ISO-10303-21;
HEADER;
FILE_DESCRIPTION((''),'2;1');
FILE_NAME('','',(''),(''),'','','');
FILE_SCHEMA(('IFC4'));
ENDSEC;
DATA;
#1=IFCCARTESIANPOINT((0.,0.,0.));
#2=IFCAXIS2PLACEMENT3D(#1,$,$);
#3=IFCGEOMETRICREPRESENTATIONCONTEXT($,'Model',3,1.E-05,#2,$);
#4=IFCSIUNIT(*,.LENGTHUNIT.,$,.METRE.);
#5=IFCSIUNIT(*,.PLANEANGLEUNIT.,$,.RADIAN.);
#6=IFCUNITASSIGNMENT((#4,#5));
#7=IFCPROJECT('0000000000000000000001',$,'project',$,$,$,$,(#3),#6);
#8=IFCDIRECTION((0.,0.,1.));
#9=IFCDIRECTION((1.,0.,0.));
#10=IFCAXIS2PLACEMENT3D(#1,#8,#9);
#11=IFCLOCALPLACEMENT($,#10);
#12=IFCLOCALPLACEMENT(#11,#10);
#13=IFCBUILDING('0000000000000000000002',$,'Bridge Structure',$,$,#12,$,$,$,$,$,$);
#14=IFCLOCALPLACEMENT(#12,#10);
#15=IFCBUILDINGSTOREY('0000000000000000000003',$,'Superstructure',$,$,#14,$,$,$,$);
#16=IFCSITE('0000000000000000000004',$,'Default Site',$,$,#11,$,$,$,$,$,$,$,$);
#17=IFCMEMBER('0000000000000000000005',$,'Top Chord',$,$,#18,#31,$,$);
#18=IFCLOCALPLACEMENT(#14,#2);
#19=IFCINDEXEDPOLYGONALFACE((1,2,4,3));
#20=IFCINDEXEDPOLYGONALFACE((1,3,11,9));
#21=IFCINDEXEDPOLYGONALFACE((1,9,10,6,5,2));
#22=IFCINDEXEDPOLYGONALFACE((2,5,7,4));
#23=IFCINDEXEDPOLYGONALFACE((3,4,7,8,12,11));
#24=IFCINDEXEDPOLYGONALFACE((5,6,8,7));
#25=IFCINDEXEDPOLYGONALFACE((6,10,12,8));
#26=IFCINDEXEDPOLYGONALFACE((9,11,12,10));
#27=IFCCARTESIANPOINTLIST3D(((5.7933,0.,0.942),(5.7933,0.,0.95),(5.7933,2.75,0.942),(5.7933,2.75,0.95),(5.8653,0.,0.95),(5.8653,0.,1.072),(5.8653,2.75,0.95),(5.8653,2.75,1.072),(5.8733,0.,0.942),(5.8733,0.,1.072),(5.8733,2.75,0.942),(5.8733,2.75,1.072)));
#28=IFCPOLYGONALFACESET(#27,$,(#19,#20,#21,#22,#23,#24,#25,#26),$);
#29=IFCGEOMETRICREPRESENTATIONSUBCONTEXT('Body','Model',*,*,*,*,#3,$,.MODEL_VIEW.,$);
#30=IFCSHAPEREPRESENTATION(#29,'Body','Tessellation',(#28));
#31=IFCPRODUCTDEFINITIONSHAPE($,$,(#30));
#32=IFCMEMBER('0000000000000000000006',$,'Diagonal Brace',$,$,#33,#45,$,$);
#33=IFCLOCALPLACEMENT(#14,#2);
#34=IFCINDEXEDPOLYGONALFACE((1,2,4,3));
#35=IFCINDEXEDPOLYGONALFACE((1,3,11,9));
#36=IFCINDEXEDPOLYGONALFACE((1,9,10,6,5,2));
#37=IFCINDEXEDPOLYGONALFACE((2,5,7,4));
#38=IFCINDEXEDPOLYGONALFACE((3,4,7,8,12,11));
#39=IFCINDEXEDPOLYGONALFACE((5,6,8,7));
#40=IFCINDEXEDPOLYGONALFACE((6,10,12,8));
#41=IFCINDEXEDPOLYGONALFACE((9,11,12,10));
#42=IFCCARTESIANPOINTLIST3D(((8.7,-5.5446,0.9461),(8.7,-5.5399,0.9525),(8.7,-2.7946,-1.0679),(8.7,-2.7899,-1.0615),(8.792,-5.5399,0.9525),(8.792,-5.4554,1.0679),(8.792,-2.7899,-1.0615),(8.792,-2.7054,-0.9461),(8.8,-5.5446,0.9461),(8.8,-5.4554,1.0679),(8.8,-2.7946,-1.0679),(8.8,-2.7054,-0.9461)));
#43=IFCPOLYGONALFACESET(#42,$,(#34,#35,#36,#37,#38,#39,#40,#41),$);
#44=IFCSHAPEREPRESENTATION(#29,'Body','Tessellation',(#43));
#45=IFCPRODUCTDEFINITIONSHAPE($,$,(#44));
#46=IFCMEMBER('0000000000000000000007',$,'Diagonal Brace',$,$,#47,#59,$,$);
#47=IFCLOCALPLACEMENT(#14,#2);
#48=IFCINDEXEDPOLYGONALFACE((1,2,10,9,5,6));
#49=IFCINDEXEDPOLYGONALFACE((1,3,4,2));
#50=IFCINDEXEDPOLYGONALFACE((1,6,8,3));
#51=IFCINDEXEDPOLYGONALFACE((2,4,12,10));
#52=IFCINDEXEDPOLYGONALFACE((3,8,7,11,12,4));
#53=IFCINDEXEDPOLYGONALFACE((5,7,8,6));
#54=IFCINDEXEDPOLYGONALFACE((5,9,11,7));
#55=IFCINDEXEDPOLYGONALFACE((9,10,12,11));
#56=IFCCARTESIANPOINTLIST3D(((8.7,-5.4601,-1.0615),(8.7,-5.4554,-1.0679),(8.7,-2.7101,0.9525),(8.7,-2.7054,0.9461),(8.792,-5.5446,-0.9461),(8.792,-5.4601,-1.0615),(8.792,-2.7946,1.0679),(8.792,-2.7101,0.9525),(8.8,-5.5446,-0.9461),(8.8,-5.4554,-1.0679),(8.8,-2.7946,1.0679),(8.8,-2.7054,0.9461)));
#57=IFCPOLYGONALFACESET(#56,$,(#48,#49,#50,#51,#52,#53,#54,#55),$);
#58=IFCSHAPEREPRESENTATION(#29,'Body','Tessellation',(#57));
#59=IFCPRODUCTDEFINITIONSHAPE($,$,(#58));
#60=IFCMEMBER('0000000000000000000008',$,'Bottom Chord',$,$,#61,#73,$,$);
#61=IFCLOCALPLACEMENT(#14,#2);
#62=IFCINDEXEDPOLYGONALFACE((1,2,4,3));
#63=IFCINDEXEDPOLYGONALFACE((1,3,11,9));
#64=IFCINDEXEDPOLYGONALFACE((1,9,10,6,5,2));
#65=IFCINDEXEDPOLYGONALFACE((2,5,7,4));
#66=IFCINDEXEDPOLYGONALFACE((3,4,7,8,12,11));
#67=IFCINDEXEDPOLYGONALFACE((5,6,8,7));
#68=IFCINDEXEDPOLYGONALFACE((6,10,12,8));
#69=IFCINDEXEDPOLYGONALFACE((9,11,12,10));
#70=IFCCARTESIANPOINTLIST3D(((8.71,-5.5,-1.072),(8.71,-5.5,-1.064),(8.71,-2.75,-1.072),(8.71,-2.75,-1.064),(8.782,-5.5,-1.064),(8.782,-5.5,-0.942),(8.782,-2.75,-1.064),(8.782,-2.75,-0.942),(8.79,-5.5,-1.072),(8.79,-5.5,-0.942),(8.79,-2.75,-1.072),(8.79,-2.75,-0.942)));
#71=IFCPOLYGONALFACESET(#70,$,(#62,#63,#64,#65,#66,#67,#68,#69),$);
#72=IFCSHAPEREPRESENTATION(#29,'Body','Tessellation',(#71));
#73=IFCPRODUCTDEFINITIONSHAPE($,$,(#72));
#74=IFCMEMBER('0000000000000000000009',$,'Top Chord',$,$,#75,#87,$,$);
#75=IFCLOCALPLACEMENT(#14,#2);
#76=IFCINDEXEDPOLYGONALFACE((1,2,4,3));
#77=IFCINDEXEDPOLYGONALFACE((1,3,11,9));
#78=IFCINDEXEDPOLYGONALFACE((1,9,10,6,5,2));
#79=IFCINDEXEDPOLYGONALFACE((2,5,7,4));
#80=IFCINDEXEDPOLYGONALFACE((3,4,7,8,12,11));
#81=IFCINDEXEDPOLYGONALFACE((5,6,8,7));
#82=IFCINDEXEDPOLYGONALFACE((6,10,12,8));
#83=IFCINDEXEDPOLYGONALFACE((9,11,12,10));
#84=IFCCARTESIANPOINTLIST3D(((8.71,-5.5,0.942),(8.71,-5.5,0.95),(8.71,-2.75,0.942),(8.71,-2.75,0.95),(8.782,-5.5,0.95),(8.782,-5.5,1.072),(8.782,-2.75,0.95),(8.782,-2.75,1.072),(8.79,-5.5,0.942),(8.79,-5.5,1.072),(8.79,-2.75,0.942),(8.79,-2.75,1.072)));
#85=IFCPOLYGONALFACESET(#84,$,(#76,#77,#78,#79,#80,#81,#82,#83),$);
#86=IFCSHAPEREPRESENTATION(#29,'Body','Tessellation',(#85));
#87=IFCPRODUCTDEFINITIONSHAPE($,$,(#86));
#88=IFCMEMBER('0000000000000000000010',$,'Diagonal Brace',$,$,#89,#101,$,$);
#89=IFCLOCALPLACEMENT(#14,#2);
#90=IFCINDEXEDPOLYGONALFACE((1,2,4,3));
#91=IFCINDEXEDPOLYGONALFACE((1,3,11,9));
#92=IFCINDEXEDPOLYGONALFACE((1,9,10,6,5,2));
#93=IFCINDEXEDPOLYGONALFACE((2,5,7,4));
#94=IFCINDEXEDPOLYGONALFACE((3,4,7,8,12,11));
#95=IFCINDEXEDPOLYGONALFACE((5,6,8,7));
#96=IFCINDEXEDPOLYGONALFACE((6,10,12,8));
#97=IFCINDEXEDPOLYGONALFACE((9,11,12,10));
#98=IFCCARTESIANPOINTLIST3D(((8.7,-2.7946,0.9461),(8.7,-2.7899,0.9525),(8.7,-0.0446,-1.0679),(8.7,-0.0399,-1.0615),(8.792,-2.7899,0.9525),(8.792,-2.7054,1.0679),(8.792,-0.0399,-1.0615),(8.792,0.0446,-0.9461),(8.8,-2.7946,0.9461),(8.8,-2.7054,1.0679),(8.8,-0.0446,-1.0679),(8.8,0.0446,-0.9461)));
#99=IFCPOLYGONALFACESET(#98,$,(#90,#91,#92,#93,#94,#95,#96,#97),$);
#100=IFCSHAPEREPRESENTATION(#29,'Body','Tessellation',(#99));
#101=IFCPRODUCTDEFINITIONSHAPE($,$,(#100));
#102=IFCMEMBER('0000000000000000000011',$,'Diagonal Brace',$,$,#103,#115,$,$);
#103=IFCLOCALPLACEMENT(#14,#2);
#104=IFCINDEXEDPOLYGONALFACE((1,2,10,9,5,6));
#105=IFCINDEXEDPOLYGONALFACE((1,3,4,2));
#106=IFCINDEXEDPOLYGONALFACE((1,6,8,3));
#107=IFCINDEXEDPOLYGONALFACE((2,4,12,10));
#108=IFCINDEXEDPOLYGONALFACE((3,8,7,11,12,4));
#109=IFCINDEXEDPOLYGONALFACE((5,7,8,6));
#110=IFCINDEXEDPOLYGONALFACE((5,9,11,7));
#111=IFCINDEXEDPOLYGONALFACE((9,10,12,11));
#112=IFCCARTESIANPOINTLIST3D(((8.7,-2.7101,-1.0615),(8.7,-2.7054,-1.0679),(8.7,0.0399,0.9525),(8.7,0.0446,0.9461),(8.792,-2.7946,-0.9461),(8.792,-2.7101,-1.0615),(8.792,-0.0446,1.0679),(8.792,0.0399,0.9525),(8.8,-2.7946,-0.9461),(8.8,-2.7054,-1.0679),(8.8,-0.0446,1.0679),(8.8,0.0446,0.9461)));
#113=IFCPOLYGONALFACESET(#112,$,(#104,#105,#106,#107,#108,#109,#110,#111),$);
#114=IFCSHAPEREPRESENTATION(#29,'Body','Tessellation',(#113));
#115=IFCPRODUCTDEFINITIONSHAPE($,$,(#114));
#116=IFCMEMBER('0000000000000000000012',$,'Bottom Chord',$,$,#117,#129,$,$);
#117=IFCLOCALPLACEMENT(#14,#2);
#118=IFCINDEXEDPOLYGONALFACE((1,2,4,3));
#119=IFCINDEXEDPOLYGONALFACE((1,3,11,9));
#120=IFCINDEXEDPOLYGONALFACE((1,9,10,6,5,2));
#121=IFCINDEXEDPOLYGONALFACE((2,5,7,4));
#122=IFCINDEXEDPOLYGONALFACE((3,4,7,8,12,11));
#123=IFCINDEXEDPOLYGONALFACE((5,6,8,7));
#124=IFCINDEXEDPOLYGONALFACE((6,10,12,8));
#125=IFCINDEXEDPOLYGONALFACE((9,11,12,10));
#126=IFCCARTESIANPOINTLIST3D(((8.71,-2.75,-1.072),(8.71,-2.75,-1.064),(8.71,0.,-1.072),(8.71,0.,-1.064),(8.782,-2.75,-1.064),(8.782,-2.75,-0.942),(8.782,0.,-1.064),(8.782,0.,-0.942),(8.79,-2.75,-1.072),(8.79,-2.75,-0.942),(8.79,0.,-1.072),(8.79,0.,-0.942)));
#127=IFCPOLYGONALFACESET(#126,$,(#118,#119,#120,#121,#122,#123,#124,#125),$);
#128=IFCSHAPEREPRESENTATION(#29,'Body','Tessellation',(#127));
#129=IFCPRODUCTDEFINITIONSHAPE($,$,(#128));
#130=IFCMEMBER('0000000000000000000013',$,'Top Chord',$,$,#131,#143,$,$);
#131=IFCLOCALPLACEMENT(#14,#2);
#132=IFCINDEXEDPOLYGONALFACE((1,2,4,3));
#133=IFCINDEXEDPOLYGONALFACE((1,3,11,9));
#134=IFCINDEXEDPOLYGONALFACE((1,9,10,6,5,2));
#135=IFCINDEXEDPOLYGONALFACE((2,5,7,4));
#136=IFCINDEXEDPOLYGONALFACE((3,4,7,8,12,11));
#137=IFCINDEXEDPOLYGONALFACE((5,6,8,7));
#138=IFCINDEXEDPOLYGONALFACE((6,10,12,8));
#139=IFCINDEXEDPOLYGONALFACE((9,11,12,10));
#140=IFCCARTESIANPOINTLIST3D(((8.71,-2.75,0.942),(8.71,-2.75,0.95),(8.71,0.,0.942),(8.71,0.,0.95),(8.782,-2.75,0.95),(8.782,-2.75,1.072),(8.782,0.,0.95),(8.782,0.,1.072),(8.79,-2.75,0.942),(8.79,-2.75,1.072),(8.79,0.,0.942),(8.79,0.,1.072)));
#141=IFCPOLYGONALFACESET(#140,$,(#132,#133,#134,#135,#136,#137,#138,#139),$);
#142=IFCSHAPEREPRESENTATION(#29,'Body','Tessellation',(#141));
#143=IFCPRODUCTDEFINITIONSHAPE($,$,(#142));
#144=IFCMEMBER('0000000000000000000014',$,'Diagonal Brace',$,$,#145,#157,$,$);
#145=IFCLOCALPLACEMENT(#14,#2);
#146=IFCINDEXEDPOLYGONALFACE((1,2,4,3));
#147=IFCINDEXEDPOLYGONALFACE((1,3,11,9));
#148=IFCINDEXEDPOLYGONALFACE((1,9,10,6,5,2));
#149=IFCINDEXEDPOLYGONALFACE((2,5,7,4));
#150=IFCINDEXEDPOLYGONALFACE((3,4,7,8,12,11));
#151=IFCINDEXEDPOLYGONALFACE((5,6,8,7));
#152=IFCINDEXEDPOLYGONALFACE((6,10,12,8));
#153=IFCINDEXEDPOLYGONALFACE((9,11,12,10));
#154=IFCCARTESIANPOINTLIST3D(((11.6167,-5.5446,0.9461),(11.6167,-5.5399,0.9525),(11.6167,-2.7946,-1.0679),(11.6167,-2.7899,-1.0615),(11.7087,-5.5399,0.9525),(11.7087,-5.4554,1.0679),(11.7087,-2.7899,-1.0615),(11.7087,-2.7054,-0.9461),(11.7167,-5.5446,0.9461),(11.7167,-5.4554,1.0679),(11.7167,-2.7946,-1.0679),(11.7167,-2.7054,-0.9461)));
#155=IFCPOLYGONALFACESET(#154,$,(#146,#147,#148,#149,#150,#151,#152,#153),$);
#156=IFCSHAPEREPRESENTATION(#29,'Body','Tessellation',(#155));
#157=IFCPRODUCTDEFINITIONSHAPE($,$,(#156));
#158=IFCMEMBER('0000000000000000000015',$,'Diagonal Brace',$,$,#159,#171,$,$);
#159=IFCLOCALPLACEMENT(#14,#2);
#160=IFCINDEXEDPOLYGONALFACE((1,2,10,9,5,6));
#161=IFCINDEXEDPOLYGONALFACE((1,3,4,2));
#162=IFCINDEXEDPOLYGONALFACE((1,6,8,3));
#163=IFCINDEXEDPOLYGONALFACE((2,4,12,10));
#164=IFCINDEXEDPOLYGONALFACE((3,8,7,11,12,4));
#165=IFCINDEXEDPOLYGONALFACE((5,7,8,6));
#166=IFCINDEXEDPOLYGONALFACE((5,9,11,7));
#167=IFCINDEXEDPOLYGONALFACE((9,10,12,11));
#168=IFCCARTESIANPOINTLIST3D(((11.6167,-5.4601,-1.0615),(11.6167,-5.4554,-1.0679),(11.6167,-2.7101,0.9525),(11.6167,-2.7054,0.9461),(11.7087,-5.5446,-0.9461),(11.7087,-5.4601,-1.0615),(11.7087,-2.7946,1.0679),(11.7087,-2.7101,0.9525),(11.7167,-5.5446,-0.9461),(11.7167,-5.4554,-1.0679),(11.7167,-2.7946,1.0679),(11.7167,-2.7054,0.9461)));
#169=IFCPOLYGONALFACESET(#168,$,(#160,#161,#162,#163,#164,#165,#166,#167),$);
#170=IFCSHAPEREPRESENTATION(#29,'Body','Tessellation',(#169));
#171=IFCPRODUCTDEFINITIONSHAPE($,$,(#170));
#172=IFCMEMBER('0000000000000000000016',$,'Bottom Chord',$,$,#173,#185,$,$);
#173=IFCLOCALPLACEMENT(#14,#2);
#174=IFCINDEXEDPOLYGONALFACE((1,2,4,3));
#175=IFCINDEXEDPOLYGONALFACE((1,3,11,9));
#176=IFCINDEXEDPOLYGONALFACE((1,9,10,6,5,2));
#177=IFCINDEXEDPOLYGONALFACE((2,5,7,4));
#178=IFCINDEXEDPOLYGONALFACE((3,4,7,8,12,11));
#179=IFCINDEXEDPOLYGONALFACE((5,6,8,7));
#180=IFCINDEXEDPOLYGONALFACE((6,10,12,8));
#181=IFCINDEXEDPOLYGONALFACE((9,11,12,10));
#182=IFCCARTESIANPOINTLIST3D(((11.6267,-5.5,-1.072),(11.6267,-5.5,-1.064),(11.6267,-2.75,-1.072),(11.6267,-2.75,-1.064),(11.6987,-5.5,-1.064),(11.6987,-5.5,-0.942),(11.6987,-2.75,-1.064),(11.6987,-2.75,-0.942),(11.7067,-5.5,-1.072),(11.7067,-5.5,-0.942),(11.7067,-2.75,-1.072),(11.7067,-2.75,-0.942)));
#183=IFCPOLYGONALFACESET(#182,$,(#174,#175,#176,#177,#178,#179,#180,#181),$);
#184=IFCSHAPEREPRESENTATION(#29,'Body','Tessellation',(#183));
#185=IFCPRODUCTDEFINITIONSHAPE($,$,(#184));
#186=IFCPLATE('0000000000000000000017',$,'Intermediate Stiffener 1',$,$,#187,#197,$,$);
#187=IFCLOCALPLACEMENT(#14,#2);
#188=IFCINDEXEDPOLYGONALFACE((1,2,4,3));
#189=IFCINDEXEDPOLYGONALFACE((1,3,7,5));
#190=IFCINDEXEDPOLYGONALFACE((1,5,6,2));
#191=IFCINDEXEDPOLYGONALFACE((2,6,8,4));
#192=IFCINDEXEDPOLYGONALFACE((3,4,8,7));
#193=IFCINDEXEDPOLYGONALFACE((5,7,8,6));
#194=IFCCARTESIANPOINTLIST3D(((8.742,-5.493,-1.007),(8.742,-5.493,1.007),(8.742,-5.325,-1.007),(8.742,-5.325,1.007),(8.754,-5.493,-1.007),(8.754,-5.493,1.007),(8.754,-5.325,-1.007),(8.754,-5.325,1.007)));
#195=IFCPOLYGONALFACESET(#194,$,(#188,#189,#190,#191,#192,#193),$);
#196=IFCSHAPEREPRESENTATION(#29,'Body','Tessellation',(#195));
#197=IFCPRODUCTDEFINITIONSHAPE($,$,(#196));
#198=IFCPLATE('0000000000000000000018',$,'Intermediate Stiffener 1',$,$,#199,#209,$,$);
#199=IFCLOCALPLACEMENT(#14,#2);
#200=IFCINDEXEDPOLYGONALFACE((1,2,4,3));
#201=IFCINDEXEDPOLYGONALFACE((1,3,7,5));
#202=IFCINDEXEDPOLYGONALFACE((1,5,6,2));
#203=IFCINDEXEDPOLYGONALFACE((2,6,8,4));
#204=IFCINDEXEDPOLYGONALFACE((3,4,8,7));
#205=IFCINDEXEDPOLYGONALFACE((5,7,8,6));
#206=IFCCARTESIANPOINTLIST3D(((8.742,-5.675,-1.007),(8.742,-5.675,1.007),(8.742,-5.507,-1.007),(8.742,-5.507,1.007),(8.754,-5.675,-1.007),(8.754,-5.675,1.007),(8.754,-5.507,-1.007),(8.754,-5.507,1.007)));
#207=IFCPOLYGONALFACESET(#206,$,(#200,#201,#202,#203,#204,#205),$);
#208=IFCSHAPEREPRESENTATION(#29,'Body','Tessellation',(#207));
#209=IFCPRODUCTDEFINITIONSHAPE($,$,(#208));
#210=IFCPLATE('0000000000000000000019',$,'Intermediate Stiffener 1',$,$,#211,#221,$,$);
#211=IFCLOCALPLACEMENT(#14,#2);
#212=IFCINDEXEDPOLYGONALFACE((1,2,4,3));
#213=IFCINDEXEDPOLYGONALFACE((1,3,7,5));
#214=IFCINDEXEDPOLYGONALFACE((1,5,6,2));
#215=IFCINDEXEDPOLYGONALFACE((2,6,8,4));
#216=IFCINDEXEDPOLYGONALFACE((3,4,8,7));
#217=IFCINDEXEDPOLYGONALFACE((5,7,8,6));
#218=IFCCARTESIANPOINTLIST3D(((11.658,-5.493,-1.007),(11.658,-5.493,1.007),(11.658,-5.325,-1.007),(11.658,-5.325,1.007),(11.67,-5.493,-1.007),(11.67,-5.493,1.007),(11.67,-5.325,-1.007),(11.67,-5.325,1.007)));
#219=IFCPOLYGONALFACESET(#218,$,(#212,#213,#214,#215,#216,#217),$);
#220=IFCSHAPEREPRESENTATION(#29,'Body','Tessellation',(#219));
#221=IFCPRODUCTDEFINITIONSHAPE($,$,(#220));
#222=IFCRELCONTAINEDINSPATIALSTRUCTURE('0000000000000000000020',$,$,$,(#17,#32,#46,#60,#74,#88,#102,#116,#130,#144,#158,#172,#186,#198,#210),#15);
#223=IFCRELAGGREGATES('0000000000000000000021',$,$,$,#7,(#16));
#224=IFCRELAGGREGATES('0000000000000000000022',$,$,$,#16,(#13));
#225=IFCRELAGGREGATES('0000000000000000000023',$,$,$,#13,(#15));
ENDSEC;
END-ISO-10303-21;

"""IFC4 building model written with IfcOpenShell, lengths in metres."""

from ifc_helpers import new_model, si_unit, frame, origin, origin_with_axes, origin_2d_with_axis, place, context, subcontext, project, spatial, rectangle, l_section, extrude, element, save


model = new_model("IFC4")

# Units and contexts
model_context = context("Model", 3, precision=1e-05, world=origin())
body_context = subcontext(model_context, "Body", "Model", "MODEL_VIEW")
ifc_project = project(units=[si_unit("LENGTHUNIT", "METRE"), si_unit("PLANEANGLEUNIT", "RADIAN")], contexts=[model_context])

# Site, building, storey
site_placement = place(None, origin_with_axes())
site = spatial("IfcSite", under=ifc_project, at=site_placement, Name="Default Site")
building_placement = place(site_placement, origin_with_axes())
building = spatial("IfcBuilding", under=site, at=building_placement, Name="Bridge Structure")
storey_placement = place(building_placement, origin_with_axes())
storey = spatial("IfcBuildingStorey", under=building, at=storey_placement, Name="Superstructure")

# Members
member_1_placement = place(storey_placement, frame((5.8333, 0.0, 1.007), z_axis=(0.0, 1.0, 0.0), x_axis=(-1.0, 0.0, 0.0)))
element("IfcMember", 1, at=member_1_placement, inside=storey, Name="Top Chord", context=body_context, shape_type="SweptSolid", body=[
    extrude(l_section(Depth=0.13, Width=0.08, Thickness=0.008, at=origin_2d_with_axis()), origin_with_axes(), (0.0, 0.0, 1.0), 2.75),
])
for number, where, z_axis, x_axis, name in (
    (2, (8.75, -5.5, 1.007), (0.0, 0.806778, -0.590855), (-1.0, 0.0, 0.0), "Diagonal Brace"),
    (3, (8.75, -5.5, -1.007), (0.0, 0.806778, 0.590855), (-1.0, 0.0, 0.0), "Diagonal Brace"),
):
    element("IfcMember", number, at=place(storey_placement, frame(where, z_axis=z_axis, x_axis=x_axis)), inside=storey, Name=name, context=body_context, shape_type="SweptSolid", body=[
        extrude(l_section(Depth=0.151, Width=0.1, Thickness=0.008, at=origin_2d_with_axis()), origin_with_axes(), (0.0, 0.0, 1.0), 3.4086),
    ])
for number, where, z_axis, x_axis, name in (
    (4, (8.75, -5.5, -1.007), (0.0, 1.0, 0.0), (-1.0, 0.0, 0.0), "Bottom Chord"),
    (5, (8.75, -5.5, 1.007), (0.0, 1.0, 0.0), (-1.0, 0.0, 0.0), "Top Chord"),
):
    element("IfcMember", number, at=place(storey_placement, frame(where, z_axis=z_axis, x_axis=x_axis)), inside=storey, Name=name, context=body_context, shape_type="SweptSolid", body=[
        extrude(l_section(Depth=0.13, Width=0.08, Thickness=0.008, at=origin_2d_with_axis()), origin_with_axes(), (0.0, 0.0, 1.0), 2.75),
    ])
for number, where, z_axis, x_axis, name in (
    (6, (8.75, -2.75, 1.007), (0.0, 0.806778, -0.590855), (-1.0, 0.0, 0.0), "Diagonal Brace"),
    (7, (8.75, -2.75, -1.007), (0.0, 0.806778, 0.590855), (-1.0, 0.0, 0.0), "Diagonal Brace"),
):
    element("IfcMember", number, at=place(storey_placement, frame(where, z_axis=z_axis, x_axis=x_axis)), inside=storey, Name=name, context=body_context, shape_type="SweptSolid", body=[
        extrude(l_section(Depth=0.151, Width=0.1, Thickness=0.008, at=origin_2d_with_axis()), origin_with_axes(), (0.0, 0.0, 1.0), 3.4086),
    ])
for number, where, z_axis, x_axis, name in (
    (8, (8.75, -2.75, -1.007), (0.0, 1.0, 0.0), (-1.0, 0.0, 0.0), "Bottom Chord"),
    (9, (8.75, -2.75, 1.007), (0.0, 1.0, 0.0), (-1.0, 0.0, 0.0), "Top Chord"),
):
    element("IfcMember", number, at=place(storey_placement, frame(where, z_axis=z_axis, x_axis=x_axis)), inside=storey, Name=name, context=body_context, shape_type="SweptSolid", body=[
        extrude(l_section(Depth=0.13, Width=0.08, Thickness=0.008, at=origin_2d_with_axis()), origin_with_axes(), (0.0, 0.0, 1.0), 2.75),
    ])
for number, where, z_axis, x_axis, name in (
    (10, (11.6667, -5.5, 1.007), (0.0, 0.806778, -0.590855), (-1.0, 0.0, 0.0), "Diagonal Brace"),
    (11, (11.6667, -5.5, -1.007), (0.0, 0.806778, 0.590855), (-1.0, 0.0, 0.0), "Diagonal Brace"),
):
    element("IfcMember", number, at=place(storey_placement, frame(where, z_axis=z_axis, x_axis=x_axis)), inside=storey, Name=name, context=body_context, shape_type="SweptSolid", body=[
        extrude(l_section(Depth=0.151, Width=0.1, Thickness=0.008, at=origin_2d_with_axis()), origin_with_axes(), (0.0, 0.0, 1.0), 3.4086),
    ])
member_2_placement = place(storey_placement, frame((11.6667, -5.5, -1.007), z_axis=(0.0, 1.0, 0.0), x_axis=(-1.0, 0.0, 0.0)))
element("IfcMember", 12, at=member_2_placement, inside=storey, Name="Bottom Chord", context=body_context, shape_type="SweptSolid", body=[
    extrude(l_section(Depth=0.13, Width=0.08, Thickness=0.008, at=origin_2d_with_axis()), origin_with_axes(), (0.0, 0.0, 1.0), 2.75),
])

# Plates
for number, where, z_axis, x_axis, name in (
    (13, (8.748, -5.409, -1.007), (0.0, 0.0, 1.0), (1.0, 0.0, 0.0), "Intermediate Stiffener 1"),
    (14, (8.748, -5.591, -1.007), (0.0, 0.0, 1.0), (1.0, 0.0, 0.0), "Intermediate Stiffener 1"),
    (15, (11.664, -5.409, -1.007), (0.0, 0.0, 1.0), (1.0, 0.0, 0.0), "Intermediate Stiffener 1"),
):
    element("IfcPlate", number, at=place(storey_placement, frame(where, z_axis=z_axis, x_axis=x_axis)), inside=storey, Name=name, context=body_context, shape_type="SweptSolid", body=[
        extrude(rectangle(XDim=0.012, YDim=0.168, at=origin_2d_with_axis()), origin_with_axes(), (0.0, 0.0, 1.0), 2.014),
    ])

save(model, "model.ifc")
